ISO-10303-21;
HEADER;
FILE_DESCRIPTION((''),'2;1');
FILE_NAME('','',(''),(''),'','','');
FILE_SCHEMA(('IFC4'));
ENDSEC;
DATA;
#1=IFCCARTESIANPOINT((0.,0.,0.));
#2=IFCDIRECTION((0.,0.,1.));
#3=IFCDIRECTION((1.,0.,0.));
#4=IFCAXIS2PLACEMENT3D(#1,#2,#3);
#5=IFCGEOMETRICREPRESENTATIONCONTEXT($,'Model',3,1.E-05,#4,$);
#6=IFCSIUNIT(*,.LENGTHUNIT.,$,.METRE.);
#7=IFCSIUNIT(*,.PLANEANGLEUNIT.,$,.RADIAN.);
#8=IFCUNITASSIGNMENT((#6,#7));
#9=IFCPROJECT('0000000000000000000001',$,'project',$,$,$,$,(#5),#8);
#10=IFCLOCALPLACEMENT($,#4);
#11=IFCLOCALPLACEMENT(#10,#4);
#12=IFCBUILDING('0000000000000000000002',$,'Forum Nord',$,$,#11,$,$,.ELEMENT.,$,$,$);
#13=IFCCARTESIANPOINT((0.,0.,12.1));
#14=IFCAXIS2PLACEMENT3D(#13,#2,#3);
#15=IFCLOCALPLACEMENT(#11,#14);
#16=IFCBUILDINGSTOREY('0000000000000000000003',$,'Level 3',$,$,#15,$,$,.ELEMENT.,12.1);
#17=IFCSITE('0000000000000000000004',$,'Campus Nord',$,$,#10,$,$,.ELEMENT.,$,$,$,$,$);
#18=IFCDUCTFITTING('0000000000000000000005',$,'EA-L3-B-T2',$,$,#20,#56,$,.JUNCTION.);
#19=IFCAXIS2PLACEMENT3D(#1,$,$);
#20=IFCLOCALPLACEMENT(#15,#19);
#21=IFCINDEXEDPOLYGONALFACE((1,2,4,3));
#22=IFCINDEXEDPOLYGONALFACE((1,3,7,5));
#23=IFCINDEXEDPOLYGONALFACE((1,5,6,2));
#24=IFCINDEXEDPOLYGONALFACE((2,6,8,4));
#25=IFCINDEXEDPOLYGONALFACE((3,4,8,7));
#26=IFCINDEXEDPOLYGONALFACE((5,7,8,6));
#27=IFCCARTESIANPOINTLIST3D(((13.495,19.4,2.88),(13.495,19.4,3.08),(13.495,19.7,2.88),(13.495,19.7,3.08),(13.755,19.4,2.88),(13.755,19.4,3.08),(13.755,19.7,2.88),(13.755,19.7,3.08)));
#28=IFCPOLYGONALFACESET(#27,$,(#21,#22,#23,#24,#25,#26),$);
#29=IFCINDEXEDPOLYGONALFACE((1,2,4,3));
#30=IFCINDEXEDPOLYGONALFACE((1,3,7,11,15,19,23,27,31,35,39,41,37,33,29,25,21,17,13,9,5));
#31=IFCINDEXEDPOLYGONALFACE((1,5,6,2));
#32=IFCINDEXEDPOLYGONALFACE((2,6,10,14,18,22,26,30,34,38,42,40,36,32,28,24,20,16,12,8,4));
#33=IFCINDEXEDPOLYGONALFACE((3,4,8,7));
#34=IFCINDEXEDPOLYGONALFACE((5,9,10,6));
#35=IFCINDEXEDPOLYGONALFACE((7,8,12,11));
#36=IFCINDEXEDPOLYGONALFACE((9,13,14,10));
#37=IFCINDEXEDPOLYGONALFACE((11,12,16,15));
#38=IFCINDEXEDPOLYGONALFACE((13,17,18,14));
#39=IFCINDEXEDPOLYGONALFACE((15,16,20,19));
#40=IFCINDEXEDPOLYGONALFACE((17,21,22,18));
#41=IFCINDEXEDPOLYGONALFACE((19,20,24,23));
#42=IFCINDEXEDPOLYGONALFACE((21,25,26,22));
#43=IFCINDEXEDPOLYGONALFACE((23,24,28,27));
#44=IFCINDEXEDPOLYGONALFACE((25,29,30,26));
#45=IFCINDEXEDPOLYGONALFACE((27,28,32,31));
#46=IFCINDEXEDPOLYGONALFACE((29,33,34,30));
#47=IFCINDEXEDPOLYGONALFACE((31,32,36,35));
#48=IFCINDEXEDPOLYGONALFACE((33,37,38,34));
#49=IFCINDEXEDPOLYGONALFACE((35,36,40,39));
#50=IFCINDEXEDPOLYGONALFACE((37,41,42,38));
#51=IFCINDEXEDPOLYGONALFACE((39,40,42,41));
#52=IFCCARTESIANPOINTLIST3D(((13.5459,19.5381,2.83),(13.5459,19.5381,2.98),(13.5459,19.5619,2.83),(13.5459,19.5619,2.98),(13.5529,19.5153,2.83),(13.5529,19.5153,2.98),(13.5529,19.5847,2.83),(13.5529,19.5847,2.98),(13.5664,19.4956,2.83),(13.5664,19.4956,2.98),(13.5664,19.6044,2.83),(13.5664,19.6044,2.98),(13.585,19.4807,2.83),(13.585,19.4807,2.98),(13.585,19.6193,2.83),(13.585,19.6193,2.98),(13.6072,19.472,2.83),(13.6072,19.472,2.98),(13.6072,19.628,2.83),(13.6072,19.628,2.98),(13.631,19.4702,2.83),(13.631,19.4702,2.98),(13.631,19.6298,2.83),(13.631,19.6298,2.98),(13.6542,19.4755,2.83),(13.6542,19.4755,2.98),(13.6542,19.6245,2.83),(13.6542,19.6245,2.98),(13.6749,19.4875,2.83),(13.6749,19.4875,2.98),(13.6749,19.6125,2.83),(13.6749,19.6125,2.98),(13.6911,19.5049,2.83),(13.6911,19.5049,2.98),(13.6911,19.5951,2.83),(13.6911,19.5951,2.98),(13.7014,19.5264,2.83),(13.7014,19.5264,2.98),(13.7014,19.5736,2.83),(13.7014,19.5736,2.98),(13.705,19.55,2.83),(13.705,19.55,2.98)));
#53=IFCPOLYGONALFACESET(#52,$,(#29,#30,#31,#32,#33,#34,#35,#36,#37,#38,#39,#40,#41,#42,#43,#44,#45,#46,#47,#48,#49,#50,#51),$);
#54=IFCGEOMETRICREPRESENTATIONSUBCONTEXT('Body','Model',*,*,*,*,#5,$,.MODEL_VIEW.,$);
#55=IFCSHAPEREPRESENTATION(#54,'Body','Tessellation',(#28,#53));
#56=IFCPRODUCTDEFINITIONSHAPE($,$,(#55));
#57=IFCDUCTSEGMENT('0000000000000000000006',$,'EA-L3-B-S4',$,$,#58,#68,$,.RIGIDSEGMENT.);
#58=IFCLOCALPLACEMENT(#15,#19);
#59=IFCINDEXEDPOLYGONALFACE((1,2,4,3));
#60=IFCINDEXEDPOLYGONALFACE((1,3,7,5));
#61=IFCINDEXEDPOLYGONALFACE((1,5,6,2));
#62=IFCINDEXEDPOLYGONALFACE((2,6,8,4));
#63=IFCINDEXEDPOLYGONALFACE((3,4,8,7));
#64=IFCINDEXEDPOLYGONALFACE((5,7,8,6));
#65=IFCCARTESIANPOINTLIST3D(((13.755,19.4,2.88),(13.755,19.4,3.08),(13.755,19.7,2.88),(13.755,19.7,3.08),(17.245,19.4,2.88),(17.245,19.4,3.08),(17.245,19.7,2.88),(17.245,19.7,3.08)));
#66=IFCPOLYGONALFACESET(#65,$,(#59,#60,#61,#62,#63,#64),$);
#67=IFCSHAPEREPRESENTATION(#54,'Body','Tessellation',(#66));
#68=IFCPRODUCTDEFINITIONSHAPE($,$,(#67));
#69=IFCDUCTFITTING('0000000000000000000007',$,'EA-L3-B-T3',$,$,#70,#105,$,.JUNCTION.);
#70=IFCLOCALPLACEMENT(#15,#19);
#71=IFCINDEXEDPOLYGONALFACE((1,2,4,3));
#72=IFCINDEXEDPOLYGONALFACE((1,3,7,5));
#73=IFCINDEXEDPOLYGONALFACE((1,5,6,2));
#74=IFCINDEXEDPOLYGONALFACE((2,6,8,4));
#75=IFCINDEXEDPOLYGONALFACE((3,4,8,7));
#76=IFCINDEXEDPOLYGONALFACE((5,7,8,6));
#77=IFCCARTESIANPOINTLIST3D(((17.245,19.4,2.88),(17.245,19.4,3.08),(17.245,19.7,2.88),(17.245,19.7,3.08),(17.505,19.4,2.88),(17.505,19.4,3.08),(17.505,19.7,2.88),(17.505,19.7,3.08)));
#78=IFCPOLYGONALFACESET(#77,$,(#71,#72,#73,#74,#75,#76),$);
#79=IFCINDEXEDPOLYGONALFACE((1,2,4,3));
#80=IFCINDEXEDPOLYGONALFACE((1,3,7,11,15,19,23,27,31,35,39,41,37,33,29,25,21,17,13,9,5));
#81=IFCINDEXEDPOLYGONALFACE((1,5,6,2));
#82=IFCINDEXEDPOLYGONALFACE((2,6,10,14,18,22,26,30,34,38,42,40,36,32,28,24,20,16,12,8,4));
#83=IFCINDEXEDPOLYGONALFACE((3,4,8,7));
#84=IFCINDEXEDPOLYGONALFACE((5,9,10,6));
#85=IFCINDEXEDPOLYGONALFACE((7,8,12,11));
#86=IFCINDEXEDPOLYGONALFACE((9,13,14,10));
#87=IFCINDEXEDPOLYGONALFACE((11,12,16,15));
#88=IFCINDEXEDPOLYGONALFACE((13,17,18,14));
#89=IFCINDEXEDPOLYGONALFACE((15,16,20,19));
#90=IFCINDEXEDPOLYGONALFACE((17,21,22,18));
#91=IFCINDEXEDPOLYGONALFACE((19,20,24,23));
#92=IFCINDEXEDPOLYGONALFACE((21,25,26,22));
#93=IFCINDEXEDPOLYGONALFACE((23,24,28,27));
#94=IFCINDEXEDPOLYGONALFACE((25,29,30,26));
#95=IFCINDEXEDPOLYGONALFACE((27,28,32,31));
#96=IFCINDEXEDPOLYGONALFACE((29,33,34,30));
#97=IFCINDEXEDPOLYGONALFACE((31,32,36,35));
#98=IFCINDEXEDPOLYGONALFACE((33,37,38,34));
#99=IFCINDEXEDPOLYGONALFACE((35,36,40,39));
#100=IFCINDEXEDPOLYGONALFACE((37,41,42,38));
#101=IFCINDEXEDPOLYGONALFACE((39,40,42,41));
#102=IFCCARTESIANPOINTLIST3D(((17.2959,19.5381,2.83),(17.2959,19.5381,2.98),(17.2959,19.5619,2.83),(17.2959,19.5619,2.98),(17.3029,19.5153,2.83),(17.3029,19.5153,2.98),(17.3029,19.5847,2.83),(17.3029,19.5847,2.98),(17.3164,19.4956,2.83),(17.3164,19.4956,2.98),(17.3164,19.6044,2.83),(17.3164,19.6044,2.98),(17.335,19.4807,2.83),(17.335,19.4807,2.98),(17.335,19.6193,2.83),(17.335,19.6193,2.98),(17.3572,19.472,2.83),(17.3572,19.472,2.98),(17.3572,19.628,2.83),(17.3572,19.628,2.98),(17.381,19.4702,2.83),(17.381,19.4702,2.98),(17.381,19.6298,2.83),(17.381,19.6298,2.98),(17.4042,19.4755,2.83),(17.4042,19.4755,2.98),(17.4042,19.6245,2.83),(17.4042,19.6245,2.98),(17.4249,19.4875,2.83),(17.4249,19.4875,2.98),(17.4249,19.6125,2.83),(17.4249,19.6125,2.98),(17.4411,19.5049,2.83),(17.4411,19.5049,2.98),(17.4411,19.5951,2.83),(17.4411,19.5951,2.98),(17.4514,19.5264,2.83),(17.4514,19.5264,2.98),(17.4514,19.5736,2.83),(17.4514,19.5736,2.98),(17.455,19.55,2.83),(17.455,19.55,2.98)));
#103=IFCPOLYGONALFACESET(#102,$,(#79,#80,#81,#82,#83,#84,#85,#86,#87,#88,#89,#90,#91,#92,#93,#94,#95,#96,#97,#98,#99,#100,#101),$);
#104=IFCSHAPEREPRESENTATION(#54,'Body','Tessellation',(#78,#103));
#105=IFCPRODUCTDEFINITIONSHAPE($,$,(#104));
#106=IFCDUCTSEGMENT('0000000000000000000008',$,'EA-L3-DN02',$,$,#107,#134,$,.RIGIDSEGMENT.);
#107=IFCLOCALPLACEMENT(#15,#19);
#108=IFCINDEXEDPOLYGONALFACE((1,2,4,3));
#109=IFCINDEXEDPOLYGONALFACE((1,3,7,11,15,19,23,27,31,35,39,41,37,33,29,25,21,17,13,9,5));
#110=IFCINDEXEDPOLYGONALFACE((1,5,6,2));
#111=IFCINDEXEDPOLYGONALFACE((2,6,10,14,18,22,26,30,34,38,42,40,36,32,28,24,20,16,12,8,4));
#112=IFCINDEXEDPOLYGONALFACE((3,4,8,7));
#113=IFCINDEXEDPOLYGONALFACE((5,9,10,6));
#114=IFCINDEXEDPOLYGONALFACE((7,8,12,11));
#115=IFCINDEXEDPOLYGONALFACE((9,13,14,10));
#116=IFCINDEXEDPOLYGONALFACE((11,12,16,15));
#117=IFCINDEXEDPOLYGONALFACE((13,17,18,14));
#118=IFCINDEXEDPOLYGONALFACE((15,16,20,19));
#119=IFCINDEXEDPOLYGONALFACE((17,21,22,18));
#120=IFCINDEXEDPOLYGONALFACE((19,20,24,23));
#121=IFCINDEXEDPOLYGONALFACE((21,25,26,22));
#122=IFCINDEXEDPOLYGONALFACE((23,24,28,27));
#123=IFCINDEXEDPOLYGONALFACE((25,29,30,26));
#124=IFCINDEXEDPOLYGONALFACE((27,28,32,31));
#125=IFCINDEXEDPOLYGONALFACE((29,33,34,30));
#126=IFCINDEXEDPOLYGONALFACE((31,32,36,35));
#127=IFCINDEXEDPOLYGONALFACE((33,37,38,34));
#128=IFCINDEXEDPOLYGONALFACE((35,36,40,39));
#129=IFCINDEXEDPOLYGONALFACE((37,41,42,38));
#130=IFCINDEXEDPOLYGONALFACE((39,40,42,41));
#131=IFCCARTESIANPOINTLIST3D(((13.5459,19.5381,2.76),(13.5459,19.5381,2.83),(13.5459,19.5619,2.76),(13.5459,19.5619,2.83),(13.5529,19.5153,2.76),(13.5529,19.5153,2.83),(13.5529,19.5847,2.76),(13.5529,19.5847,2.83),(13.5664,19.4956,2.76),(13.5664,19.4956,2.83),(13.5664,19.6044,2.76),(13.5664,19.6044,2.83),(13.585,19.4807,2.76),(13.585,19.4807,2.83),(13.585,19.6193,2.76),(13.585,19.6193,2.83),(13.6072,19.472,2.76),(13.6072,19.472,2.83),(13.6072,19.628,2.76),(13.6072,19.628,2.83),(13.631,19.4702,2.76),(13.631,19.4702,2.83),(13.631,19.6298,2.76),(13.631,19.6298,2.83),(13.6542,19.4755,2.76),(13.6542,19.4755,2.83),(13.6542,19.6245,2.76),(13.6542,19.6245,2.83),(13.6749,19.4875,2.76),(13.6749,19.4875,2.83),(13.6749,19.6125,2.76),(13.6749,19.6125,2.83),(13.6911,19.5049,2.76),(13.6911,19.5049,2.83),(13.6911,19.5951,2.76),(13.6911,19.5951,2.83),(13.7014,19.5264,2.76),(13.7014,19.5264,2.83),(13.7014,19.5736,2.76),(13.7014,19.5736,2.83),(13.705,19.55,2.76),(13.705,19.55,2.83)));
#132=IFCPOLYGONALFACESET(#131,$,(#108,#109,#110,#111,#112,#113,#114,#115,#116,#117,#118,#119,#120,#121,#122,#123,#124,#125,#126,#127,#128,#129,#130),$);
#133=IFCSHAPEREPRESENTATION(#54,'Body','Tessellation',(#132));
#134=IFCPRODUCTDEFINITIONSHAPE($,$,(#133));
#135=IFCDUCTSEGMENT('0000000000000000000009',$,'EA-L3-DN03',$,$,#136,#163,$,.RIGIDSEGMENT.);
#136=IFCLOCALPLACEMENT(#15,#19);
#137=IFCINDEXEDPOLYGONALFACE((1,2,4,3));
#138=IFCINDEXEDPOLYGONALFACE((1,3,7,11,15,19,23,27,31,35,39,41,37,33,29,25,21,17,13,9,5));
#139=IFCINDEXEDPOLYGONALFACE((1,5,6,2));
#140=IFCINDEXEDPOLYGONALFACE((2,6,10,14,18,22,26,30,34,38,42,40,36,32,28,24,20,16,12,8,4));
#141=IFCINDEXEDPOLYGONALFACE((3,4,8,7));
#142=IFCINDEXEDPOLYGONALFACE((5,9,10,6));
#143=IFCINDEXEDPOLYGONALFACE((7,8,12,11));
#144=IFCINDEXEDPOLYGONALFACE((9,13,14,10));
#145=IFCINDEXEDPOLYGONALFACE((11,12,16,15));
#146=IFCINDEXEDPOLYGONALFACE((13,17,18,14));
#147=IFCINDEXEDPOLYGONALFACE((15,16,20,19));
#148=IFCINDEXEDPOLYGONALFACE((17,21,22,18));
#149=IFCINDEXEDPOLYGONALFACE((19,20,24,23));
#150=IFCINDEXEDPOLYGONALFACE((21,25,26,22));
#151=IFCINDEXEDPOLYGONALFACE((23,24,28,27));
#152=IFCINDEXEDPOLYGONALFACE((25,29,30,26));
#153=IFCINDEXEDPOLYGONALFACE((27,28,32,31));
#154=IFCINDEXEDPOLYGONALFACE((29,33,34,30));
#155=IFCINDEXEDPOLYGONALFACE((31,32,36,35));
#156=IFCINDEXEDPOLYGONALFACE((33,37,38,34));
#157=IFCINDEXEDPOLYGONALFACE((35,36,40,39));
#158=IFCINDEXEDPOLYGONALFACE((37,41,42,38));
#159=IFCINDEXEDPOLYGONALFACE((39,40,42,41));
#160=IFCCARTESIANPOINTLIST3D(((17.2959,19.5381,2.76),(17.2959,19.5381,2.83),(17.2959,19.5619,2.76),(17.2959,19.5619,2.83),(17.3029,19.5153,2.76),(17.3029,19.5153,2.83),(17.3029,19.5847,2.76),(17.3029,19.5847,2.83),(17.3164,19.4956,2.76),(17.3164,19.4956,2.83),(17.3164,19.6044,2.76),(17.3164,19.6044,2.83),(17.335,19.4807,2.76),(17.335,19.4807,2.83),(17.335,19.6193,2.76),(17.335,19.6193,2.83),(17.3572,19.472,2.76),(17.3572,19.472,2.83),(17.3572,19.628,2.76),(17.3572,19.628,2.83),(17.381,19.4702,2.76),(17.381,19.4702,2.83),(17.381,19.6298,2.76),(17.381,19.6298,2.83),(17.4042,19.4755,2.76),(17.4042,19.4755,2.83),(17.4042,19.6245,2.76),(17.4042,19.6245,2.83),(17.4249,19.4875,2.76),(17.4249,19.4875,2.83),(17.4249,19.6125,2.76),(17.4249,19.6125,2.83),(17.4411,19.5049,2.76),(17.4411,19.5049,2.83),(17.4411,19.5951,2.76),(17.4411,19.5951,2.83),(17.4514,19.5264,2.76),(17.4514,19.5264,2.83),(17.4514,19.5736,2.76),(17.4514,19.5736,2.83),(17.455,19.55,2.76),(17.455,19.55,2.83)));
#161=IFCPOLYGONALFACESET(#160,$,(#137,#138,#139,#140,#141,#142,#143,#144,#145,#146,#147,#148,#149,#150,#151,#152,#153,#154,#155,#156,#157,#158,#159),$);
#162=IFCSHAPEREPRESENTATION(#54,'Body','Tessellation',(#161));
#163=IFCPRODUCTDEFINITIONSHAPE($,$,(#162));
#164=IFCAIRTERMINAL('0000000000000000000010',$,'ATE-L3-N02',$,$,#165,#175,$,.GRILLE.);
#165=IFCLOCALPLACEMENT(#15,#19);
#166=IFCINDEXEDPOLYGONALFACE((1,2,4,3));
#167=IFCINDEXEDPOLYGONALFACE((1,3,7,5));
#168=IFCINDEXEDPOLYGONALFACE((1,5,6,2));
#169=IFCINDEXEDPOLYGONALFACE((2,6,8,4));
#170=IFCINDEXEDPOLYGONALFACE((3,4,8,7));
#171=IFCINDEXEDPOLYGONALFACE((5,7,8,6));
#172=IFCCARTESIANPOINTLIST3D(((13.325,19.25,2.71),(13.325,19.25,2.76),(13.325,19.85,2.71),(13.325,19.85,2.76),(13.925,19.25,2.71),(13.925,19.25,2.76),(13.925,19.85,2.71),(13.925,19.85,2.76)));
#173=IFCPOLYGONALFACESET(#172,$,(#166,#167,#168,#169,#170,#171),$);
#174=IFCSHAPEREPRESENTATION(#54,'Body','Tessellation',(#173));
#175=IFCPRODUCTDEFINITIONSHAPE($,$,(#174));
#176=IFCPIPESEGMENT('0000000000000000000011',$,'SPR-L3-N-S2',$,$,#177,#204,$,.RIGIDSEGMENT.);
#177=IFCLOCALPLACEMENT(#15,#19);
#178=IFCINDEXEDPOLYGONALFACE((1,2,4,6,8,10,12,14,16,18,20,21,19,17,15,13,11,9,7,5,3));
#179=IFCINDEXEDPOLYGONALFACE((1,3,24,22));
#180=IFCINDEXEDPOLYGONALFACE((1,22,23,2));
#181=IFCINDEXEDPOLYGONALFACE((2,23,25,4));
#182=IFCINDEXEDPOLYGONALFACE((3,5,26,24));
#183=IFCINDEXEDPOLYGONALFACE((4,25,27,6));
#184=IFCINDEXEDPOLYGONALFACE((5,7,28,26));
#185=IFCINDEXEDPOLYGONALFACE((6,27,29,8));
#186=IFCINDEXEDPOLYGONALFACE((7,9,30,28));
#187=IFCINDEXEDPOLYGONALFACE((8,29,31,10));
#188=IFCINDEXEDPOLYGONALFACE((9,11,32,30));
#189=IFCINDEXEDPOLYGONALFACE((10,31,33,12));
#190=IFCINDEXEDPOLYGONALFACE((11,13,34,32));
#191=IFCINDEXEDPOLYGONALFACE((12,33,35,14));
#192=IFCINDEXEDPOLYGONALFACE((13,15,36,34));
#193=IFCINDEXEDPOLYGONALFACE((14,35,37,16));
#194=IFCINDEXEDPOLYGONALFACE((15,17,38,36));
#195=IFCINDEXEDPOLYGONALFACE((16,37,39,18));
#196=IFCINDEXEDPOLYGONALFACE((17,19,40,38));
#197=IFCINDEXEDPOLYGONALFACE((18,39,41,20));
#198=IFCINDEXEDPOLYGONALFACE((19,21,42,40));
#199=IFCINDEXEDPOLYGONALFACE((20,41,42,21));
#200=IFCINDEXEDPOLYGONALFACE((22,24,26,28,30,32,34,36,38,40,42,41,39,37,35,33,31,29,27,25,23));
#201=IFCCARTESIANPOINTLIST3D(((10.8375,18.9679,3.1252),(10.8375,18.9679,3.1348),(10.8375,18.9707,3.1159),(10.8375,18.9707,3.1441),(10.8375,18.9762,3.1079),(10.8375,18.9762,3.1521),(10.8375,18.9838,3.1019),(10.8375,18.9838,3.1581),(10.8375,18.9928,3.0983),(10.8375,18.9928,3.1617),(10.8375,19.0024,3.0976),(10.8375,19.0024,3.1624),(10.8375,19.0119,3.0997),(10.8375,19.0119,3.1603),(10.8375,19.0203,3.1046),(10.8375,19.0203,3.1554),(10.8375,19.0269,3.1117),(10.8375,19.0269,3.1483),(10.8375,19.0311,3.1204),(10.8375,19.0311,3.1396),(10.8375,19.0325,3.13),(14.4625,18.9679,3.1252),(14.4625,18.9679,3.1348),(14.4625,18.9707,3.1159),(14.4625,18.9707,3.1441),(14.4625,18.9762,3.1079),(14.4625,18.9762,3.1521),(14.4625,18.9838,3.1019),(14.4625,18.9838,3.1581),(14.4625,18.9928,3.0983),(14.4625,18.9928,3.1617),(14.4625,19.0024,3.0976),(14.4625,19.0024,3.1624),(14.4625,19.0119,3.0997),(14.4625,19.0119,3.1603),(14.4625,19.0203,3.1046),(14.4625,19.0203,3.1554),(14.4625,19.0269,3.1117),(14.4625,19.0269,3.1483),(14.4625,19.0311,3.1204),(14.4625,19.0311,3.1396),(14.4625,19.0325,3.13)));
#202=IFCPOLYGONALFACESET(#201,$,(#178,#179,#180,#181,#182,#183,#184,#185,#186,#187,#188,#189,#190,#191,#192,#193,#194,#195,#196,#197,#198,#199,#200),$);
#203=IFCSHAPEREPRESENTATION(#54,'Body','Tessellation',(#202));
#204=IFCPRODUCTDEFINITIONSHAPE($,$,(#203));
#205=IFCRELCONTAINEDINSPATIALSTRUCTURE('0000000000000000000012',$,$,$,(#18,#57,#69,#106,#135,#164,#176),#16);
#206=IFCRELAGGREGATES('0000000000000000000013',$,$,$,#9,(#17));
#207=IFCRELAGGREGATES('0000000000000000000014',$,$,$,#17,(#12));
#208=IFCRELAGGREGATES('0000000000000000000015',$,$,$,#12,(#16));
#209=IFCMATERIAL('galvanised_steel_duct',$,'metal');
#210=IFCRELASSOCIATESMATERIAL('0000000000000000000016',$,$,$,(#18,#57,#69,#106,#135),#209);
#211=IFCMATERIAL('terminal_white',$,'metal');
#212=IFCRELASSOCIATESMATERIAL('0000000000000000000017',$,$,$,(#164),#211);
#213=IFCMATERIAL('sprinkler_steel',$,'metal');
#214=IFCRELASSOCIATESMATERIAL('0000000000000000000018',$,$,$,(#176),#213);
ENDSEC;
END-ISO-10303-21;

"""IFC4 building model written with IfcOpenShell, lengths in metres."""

from ifc_helpers import new_model, si_unit, frame, origin_with_axes, origin_2d_with_axis, place, context, subcontext, project, spatial, rectangle, circle, extrude, material, element, save


model = new_model("IFC4")

# Units and contexts
model_context = context("Model", 3, precision=1e-05, world=origin_with_axes())
body_context = subcontext(model_context, "Body", "Model", "MODEL_VIEW")
ifc_project = project(units=[si_unit("LENGTHUNIT", "METRE"), si_unit("PLANEANGLEUNIT", "RADIAN")], contexts=[model_context])

# Site, building, storey
site_placement = place(None, origin_with_axes())
site = spatial("IfcSite", under=ifc_project, at=site_placement, Name="Campus Nord", CompositionType="ELEMENT")
building_placement = place(site_placement, origin_with_axes())
building = spatial("IfcBuilding", under=site, at=building_placement, Name="Forum Nord", CompositionType="ELEMENT")
storey_placement = place(building_placement, frame((0.0, 0.0, 12.1), z_axis=(0.0, 0.0, 1.0), x_axis=(1.0, 0.0, 0.0)))
storey = spatial("IfcBuildingStorey", under=building, at=storey_placement, Name="Level 3", CompositionType="ELEMENT", Elevation=12.1)

# Shared definitions
ifc_material_1 = material(Name="galvanised_steel_duct", Category="metal")

# Shared definitions
ifc_material_2 = material(Name="terminal_white", Category="metal")

# Duct fitting
duct_fitting_1_placement = place(storey_placement, frame((13.495, 19.55, 2.98), z_axis=(1.0, 0.0, 0.0), x_axis=(0.0, 1.0, 0.0)))
element("IfcDuctFitting", 1, at=duct_fitting_1_placement, inside=storey, material=ifc_material_1, Name="EA-L3-B-T2", PredefinedType="JUNCTION", context=body_context, shape_type="SweptSolid", body=[
    extrude(rectangle(XDim=0.3, YDim=0.2, at=origin_2d_with_axis()), origin_with_axes(), (0.0, 0.0, 1.0), 0.26),
    extrude(circle(Radius=0.08, at=origin_2d_with_axis()), frame((0.0, 0.0, 0.13), z_axis=(0.0, -1.0, 0.0), x_axis=(0.0, 0.0, 1.0)), (0.0, 0.0, 1.0), 0.15),
])

# Duct segment
duct_segment_1_placement = place(storey_placement, frame((13.755, 19.55, 2.98), z_axis=(1.0, 0.0, 0.0), x_axis=(0.0, 1.0, 0.0)))
element("IfcDuctSegment", 2, at=duct_segment_1_placement, inside=storey, material=ifc_material_1, Name="EA-L3-B-S4", PredefinedType="RIGIDSEGMENT", context=body_context, shape_type="SweptSolid", body=[
    extrude(rectangle(XDim=0.3, YDim=0.2, at=origin_2d_with_axis()), origin_with_axes(), (0.0, 0.0, 1.0), 3.49),
])

# Duct fitting
duct_fitting_2_placement = place(storey_placement, frame((17.245, 19.55, 2.98), z_axis=(1.0, 0.0, 0.0), x_axis=(0.0, 1.0, 0.0)))
element("IfcDuctFitting", 3, at=duct_fitting_2_placement, inside=storey, material=ifc_material_1, Name="EA-L3-B-T3", PredefinedType="JUNCTION", context=body_context, shape_type="SweptSolid", body=[
    extrude(rectangle(XDim=0.3, YDim=0.2, at=origin_2d_with_axis()), origin_with_axes(), (0.0, 0.0, 1.0), 0.26),
    extrude(circle(Radius=0.08, at=origin_2d_with_axis()), frame((0.0, 0.0, 0.13), z_axis=(0.0, -1.0, 0.0), x_axis=(0.0, 0.0, 1.0)), (0.0, 0.0, 1.0), 0.15),
])

# Duct segments
for number, where, z_axis, x_axis, name in (
    (4, (13.625, 19.55, 2.83), (0.0, 0.0, -1.0), (1.0, 0.0, 0.0), "EA-L3-DN02"),
    (5, (17.375, 19.55, 2.83), (0.0, 0.0, -1.0), (1.0, 0.0, 0.0), "EA-L3-DN03"),
):
    element("IfcDuctSegment", number, at=place(storey_placement, frame(where, z_axis=z_axis, x_axis=x_axis)), inside=storey, material=ifc_material_1, Name=name, PredefinedType="RIGIDSEGMENT", context=body_context, shape_type="SweptSolid", body=[
        extrude(circle(Radius=0.08, at=origin_2d_with_axis()), origin_with_axes(), (0.0, 0.0, 1.0), 0.07),
    ])

# Air terminal
air_terminal_placement = place(storey_placement, frame((13.625, 19.55, 2.71), z_axis=(0.0, 0.0, 1.0), x_axis=(1.0, 0.0, 0.0)))
element("IfcAirTerminal", 6, at=air_terminal_placement, inside=storey, material=ifc_material_2, Name="ATE-L3-N02", PredefinedType="GRILLE", context=body_context, shape_type="SweptSolid", body=[
    extrude(rectangle(XDim=0.6, YDim=0.6, at=origin_2d_with_axis()), origin_with_axes(), (0.0, 0.0, 1.0), 0.05),
])

# Pipe segment
ifc_material_3 = material(Name="sprinkler_steel", Category="metal")
pipe_segment_1_placement = place(storey_placement, frame((10.8375, 19.0, 3.13), z_axis=(1.0, 0.0, 0.0), x_axis=(0.0, 1.0, 0.0)))
element("IfcPipeSegment", 7, at=pipe_segment_1_placement, inside=storey, material=ifc_material_3, Name="SPR-L3-N-S2", PredefinedType="RIGIDSEGMENT", context=body_context, shape_type="SweptSolid", body=[
    extrude(circle(Radius=0.0325, at=origin_2d_with_axis()), origin_with_axes(), (0.0, 0.0, 1.0), 3.625),
])

save(model, "model.ifc")
